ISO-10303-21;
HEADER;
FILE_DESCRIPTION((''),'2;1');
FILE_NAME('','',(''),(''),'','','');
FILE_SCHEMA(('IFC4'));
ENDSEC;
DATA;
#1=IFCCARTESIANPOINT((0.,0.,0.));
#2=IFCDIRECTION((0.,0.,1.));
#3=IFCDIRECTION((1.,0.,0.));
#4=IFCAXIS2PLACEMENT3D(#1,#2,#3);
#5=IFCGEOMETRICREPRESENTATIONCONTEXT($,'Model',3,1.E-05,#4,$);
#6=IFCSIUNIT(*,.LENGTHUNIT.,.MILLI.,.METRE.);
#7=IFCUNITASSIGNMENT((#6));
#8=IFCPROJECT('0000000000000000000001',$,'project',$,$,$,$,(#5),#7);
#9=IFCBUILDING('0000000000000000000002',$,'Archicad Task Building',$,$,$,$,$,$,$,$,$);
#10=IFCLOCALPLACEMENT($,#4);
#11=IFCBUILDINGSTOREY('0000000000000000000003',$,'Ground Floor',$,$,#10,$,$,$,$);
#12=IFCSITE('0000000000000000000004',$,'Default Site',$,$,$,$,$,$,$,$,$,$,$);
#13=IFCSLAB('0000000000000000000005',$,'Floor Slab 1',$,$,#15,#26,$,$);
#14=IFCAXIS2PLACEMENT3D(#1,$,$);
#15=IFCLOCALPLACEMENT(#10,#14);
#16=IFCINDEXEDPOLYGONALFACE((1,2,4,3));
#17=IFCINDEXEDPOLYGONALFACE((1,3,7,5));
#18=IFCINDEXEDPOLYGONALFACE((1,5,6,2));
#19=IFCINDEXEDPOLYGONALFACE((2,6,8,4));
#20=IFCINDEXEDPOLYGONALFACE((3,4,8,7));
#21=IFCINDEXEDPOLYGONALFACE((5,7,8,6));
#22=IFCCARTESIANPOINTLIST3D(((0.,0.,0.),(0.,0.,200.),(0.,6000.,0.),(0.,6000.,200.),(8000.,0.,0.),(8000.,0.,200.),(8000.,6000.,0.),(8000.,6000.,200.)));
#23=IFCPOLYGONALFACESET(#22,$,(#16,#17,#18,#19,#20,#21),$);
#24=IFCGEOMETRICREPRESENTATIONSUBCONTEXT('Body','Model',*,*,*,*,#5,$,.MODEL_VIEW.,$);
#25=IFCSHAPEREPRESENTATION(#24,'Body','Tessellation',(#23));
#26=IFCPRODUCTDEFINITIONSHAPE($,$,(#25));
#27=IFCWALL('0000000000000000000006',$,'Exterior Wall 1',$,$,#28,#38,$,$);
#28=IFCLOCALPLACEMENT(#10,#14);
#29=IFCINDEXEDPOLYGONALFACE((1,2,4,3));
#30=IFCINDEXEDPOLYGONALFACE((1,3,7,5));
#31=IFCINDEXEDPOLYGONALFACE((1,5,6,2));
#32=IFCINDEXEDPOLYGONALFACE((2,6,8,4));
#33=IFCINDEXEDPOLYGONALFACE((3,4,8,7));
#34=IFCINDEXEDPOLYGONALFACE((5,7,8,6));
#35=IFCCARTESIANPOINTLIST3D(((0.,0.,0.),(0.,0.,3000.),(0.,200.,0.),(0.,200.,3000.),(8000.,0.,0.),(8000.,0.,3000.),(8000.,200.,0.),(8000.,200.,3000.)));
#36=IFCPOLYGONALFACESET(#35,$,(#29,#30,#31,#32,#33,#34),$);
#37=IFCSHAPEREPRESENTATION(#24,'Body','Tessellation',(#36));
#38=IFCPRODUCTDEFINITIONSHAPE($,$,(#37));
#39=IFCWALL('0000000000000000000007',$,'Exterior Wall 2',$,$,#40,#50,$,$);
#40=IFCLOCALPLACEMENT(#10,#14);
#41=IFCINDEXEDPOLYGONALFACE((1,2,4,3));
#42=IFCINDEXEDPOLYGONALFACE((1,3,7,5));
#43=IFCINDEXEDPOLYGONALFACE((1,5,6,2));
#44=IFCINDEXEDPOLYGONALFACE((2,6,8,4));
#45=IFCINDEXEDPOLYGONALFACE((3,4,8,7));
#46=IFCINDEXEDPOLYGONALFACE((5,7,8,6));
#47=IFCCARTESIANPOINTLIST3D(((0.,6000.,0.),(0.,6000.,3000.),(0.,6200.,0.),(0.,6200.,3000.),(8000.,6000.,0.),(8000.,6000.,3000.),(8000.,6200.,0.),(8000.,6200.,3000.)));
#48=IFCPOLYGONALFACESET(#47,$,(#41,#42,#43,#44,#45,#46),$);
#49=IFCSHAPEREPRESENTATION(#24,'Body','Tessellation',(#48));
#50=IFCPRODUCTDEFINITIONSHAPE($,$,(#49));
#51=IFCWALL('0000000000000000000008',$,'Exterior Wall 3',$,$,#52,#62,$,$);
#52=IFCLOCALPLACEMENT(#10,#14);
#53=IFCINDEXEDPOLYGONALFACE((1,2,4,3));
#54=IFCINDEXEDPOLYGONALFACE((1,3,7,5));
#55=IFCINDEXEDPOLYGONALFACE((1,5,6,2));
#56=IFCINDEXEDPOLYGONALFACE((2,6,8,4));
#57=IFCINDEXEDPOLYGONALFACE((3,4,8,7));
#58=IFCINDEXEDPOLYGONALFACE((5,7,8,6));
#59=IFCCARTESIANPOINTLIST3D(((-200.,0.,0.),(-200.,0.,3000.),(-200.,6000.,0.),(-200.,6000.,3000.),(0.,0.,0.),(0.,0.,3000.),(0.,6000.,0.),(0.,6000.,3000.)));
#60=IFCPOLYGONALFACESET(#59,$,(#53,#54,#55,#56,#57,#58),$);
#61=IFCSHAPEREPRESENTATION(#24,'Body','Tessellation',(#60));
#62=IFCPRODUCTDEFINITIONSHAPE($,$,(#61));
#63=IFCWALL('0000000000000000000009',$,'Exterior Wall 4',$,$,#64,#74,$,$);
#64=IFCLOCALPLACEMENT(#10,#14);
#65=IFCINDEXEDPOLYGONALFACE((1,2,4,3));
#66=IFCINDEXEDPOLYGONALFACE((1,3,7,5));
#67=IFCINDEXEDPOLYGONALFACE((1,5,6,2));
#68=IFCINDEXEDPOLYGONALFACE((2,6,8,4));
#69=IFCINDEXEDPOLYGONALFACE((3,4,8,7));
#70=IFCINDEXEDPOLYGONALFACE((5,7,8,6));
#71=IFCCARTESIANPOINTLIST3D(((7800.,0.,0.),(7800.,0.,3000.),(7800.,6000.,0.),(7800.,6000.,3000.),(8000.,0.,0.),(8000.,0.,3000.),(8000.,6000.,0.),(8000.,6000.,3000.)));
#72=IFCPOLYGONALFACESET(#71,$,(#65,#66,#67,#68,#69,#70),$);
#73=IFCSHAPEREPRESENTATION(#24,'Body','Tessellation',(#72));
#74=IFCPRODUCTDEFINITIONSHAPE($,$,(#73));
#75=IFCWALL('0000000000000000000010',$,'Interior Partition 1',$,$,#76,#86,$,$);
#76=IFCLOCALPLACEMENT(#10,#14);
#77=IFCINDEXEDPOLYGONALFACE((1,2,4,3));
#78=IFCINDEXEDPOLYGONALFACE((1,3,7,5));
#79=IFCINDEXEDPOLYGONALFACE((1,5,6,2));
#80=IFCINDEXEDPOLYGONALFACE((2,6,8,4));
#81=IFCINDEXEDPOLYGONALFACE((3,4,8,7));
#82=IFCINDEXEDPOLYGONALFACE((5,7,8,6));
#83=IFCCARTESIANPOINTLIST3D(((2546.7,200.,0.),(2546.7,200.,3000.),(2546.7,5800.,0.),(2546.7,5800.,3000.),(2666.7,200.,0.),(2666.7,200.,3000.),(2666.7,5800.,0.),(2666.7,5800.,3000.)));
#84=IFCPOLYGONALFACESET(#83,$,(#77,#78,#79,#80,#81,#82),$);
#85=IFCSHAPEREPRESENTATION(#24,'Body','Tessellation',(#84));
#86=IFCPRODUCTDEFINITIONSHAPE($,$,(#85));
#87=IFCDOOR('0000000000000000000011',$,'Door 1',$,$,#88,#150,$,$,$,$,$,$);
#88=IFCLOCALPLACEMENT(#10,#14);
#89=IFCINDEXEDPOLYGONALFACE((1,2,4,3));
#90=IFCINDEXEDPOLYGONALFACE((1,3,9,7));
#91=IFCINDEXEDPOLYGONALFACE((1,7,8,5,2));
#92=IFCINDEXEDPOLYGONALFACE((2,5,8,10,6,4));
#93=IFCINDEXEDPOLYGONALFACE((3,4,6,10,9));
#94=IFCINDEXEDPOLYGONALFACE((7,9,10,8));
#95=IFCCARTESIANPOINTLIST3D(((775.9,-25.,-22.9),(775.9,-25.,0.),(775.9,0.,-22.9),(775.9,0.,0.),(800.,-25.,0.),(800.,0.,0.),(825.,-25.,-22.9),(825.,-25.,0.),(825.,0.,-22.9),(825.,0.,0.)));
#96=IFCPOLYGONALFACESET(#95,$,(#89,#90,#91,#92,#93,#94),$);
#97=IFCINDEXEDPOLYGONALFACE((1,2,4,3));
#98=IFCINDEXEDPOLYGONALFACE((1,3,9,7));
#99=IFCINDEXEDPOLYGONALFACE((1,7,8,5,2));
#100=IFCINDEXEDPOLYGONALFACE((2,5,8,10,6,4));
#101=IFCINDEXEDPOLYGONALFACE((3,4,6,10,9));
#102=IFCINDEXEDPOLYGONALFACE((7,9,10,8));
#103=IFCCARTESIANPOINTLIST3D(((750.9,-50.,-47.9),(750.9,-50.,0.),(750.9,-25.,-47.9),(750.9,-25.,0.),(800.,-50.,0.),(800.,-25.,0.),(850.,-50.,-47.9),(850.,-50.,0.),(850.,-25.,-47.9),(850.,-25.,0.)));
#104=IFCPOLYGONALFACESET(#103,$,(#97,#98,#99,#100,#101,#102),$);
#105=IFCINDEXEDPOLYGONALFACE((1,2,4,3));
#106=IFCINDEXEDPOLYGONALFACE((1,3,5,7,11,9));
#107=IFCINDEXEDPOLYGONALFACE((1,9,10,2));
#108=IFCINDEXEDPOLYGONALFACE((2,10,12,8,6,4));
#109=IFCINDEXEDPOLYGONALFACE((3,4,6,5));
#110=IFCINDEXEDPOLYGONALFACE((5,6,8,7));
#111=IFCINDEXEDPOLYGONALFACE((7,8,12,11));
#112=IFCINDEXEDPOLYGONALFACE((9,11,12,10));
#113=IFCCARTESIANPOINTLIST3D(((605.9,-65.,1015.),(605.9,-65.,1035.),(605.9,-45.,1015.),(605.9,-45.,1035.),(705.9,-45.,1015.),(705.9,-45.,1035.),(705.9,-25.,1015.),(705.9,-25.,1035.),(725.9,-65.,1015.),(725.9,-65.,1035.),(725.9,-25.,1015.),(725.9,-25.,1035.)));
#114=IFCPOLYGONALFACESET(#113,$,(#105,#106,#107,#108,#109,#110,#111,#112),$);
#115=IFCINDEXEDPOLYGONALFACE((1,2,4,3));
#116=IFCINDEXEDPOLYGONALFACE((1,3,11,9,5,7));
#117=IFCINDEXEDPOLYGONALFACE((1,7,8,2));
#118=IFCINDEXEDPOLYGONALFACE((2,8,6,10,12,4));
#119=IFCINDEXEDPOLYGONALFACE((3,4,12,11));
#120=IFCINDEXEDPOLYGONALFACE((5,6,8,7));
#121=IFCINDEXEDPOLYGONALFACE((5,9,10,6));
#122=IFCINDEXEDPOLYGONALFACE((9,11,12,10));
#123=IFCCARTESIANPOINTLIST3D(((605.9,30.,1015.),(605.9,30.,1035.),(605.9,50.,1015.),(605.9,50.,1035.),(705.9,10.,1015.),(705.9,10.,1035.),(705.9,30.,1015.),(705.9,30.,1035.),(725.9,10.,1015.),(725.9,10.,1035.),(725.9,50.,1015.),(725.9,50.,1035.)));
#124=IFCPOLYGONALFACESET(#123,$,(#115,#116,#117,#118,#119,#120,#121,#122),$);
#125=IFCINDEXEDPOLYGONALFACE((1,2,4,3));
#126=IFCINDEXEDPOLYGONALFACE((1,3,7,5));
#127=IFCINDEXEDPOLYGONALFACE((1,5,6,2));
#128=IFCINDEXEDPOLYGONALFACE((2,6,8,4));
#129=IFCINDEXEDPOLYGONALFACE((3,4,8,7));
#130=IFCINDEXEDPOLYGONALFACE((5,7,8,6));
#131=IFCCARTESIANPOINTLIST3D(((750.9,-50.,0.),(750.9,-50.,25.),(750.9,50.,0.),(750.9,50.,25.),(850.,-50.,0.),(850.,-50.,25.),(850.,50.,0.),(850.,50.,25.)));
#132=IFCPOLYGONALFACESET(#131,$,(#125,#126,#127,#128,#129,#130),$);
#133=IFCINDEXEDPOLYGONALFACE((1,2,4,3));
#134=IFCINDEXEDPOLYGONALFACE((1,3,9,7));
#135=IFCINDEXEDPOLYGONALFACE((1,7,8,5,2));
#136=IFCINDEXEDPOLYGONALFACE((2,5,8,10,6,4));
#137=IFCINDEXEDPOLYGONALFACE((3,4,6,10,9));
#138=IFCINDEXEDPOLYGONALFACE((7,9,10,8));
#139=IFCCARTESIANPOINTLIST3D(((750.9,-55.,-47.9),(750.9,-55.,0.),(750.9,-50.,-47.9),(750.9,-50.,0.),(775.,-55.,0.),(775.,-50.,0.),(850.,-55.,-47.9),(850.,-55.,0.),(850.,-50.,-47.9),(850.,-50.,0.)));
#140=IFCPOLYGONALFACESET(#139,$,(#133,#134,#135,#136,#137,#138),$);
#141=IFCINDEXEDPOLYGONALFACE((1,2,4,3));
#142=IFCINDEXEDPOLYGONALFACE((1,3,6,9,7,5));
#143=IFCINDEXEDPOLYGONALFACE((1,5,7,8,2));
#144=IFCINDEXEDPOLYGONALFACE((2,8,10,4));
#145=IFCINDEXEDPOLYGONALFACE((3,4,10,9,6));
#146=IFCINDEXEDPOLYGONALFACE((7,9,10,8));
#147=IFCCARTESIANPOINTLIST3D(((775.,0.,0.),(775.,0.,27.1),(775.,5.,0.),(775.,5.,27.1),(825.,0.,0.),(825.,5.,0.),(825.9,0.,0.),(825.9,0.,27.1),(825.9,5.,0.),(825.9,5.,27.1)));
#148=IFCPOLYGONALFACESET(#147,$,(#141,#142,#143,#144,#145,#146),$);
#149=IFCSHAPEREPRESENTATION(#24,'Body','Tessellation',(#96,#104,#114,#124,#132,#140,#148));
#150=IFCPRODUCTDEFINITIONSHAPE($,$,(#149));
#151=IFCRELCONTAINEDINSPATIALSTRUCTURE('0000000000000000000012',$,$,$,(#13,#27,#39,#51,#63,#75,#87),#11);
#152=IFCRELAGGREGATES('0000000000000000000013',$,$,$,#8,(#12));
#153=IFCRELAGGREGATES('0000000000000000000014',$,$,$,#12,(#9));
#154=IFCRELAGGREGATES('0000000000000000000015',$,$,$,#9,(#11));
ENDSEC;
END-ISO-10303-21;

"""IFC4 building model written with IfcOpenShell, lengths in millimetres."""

from ifc_helpers import new_model, si_unit, frame, origin_with_axes, place, context, subcontext, project, spatial, line, indexed_curve, outline, extrude, element, save


model = new_model("IFC4")

# Units and contexts
model_context = context("Model", 3, precision=1e-05, world=origin_with_axes())
body_context = subcontext(model_context, "Body", "Model", "MODEL_VIEW")
ifc_project = project(units=[si_unit("LENGTHUNIT", "METRE", prefix="MILLI")], contexts=[model_context])

# Site, building, storey
site = spatial("IfcSite", under=ifc_project, Name="Default Site")
building = spatial("IfcBuilding", under=site, Name="Archicad Task Building")
storey_placement = place(None, origin_with_axes())
storey = spatial("IfcBuildingStorey", under=building, at=storey_placement, Name="Ground Floor")

# Slab
slab_placement = place(storey_placement, origin_with_axes())
element("IfcSlab", 1, at=slab_placement, inside=storey, Name="Floor Slab 1", context=body_context, shape_type="SweptSolid", body=[
    extrude(outline(indexed_curve([(0.0, 0.0), (8000.0, 0.0), (8000.0, 6000.0), (0.0, 6000.0), (0.0, 0.0)])), None, (0.0, 0.0, 1.0), 200.0),
])

# Walls
for number, where, z_axis, x_axis, name in (
    (2, (0.0, 0.0, 0.0), (0.0, 0.0, 1.0), (1.0, 0.0, 0.0), "Exterior Wall 1"),
    (3, (0.0, 6000.0, 0.0), (0.0, 0.0, 1.0), (1.0, 0.0, 0.0), "Exterior Wall 2"),
):
    element("IfcWall", number, at=place(storey_placement, frame(where, z_axis=z_axis, x_axis=x_axis)), inside=storey, Name=name, context=body_context, shape_type="SweptSolid", body=[
        extrude(outline(indexed_curve([(0.0, 0.0), (0.0, 200.0), (8000.0, 200.0), (8000.0, 0.0), (0.0, 0.0)], self_intersect=False)), origin_with_axes(), (0.0, 0.0, 1.0), 3000.0),
    ])
for number, where, z_axis, x_axis, name in (
    (4, (0.0, 0.0, 0.0), (0.0, 0.0, 1.0), (0.0, 1.0, 0.0), "Exterior Wall 3"),
    (5, (8000.0, 0.0, 0.0), (0.0, 0.0, 1.0), (0.0, 1.0, 0.0), "Exterior Wall 4"),
):
    element("IfcWall", number, at=place(storey_placement, frame(where, z_axis=z_axis, x_axis=x_axis)), inside=storey, Name=name, context=body_context, shape_type="SweptSolid", body=[
        extrude(outline(indexed_curve([(0.0, 0.0), (0.0, 200.0), (6000.0, 200.0), (6000.0, 0.0), (0.0, 0.0)], self_intersect=False)), origin_with_axes(), (0.0, 0.0, 1.0), 3000.0),
    ])
wall_placement = place(storey_placement, frame((2666.7, 200.0, 0.0), z_axis=(0.0, 0.0, 1.0), x_axis=(0.0, 1.0, 0.0)))
element("IfcWall", 6, at=wall_placement, inside=storey, Name="Interior Partition 1", context=body_context, shape_type="SweptSolid", body=[
    extrude(outline(indexed_curve([(0.0, 0.0), (0.0, 120.0), (5600.0, 120.0), (5600.0, 0.0), (0.0, 0.0)], self_intersect=False)), origin_with_axes(), (0.0, 0.0, 1.0), 3000.0),
])

# Door
door_1_placement = place(storey_placement, frame((800.0, -50.0, 0.0), z_axis=(0.0, 0.0, 1.0), x_axis=(1.0, 0.0, 0.0)))
element("IfcDoor", 7, at=door_1_placement, inside=storey, Name="Door 1", context=body_context, shape_type="SweptSolid", body=[
    extrude(outline(indexed_curve([(0.0, 0.0), (0.0, 2.1), (0.9, 2.1), (0.9, 0.0), (-24.1, 0.0), (-24.1, -22.9), (25.0, -22.9), (25.0, 0.0)], segments=[line(1, 2, 3, 4, 5, 6, 7, 8, 1)])), frame((0.0, 25.0, 0.0), z_axis=(0.0, -1.0, 0.0), x_axis=(1.0, 0.0, 0.0)), (0.0, 0.0, -1.0), 25.0),
    extrude(outline(indexed_curve([(0.0, 0.0), (0.0, 2.1), (0.9, 2.1), (0.9, 0.0), (-49.1, 0.0), (-49.1, -47.9), (50.0, -47.9), (50.0, 0.0)], segments=[line(1, 2, 3, 4, 5, 6, 7, 8, 1)])), frame((0.0, 0.0, 0.0), z_axis=(0.0, -1.0, 0.0), x_axis=(1.0, 0.0, 0.0)), (0.0, 0.0, -1.0), 25.0),
    extrude(outline(indexed_curve([(0.0, 0.0), (-49.1, 0.0), (-49.1, 35.0), (0.0, 35.0)], segments=[line(1, 2, 3, 4, 1)])), frame((25.0, 25.0, 25.0), z_axis=(0.0, 0.0, 1.0), x_axis=(1.0, 0.0, 0.0)), (0.0, 0.0, 1.0), -47.9),
    extrude(outline(indexed_curve([(0.0, 0.0), (0.0, -40.0), (-120.0, -40.0), (-120.0, -20.0), (-20.0, -20.0), (-20.0, 0.0)], segments=[line(1, 2, 3, 4, 5, 6, 1)])), frame((-74.1, 25.0, 1015.0), z_axis=(0.0, 0.0, 1.0), x_axis=(1.0, 0.0, 0.0)), (0.0, 0.0, 1.0), 20.0),
    extrude(outline(indexed_curve([(0.0, 0.0), (0.0, 40.0), (-120.0, 40.0), (-120.0, 20.0), (-20.0, 20.0), (-20.0, 0.0)], segments=[line(1, 2, 3, 4, 5, 6, 1)])), frame((-74.1, 60.0, 1015.0), z_axis=(0.0, 0.0, 1.0), x_axis=(1.0, 0.0, 0.0)), (0.0, 0.0, 1.0), 20.0),
    extrude(outline(indexed_curve([(0.0, 0.0), (-99.1, 0.0), (-99.1, 100.0), (0.0, 100.0)], segments=[line(1, 2, 3, 4, 1)])), frame((50.0, 0.0, 0.0), z_axis=(0.0, 0.0, 1.0), x_axis=(1.0, 0.0, 0.0)), (0.0, 0.0, 1.0), 25.0),
    extrude(outline(indexed_curve([(0.0, 0.0), (0.0, 27.1), (50.9, 27.1), (50.9, 0.0), (-24.1, 0.0), (-24.1, -47.9), (75.0, -47.9), (75.0, 0.0)], segments=[line(1, 2, 3, 4, 5, 6, 7, 8, 1)])), frame((-25.0, -5.0, 0.0), z_axis=(0.0, -1.0, 0.0), x_axis=(1.0, 0.0, 0.0)), (0.0, 0.0, -1.0), 5.0),
    extrude(outline(indexed_curve([(0.0, 0.0), (0.0, 27.1), (50.9, 27.1), (50.9, 0.0), (0.9, 0.0), (0.9, -22.9), (50.0, -22.9), (50.0, 0.0)], segments=[line(1, 2, 3, 4, 5, 6, 7, 8, 1)])), frame((-25.0, 50.0, 0.0), z_axis=(0.0, -1.0, 0.0), x_axis=(1.0, 0.0, 0.0)), (0.0, 0.0, -1.0), 5.0),
])

save(model, "model.ifc")
